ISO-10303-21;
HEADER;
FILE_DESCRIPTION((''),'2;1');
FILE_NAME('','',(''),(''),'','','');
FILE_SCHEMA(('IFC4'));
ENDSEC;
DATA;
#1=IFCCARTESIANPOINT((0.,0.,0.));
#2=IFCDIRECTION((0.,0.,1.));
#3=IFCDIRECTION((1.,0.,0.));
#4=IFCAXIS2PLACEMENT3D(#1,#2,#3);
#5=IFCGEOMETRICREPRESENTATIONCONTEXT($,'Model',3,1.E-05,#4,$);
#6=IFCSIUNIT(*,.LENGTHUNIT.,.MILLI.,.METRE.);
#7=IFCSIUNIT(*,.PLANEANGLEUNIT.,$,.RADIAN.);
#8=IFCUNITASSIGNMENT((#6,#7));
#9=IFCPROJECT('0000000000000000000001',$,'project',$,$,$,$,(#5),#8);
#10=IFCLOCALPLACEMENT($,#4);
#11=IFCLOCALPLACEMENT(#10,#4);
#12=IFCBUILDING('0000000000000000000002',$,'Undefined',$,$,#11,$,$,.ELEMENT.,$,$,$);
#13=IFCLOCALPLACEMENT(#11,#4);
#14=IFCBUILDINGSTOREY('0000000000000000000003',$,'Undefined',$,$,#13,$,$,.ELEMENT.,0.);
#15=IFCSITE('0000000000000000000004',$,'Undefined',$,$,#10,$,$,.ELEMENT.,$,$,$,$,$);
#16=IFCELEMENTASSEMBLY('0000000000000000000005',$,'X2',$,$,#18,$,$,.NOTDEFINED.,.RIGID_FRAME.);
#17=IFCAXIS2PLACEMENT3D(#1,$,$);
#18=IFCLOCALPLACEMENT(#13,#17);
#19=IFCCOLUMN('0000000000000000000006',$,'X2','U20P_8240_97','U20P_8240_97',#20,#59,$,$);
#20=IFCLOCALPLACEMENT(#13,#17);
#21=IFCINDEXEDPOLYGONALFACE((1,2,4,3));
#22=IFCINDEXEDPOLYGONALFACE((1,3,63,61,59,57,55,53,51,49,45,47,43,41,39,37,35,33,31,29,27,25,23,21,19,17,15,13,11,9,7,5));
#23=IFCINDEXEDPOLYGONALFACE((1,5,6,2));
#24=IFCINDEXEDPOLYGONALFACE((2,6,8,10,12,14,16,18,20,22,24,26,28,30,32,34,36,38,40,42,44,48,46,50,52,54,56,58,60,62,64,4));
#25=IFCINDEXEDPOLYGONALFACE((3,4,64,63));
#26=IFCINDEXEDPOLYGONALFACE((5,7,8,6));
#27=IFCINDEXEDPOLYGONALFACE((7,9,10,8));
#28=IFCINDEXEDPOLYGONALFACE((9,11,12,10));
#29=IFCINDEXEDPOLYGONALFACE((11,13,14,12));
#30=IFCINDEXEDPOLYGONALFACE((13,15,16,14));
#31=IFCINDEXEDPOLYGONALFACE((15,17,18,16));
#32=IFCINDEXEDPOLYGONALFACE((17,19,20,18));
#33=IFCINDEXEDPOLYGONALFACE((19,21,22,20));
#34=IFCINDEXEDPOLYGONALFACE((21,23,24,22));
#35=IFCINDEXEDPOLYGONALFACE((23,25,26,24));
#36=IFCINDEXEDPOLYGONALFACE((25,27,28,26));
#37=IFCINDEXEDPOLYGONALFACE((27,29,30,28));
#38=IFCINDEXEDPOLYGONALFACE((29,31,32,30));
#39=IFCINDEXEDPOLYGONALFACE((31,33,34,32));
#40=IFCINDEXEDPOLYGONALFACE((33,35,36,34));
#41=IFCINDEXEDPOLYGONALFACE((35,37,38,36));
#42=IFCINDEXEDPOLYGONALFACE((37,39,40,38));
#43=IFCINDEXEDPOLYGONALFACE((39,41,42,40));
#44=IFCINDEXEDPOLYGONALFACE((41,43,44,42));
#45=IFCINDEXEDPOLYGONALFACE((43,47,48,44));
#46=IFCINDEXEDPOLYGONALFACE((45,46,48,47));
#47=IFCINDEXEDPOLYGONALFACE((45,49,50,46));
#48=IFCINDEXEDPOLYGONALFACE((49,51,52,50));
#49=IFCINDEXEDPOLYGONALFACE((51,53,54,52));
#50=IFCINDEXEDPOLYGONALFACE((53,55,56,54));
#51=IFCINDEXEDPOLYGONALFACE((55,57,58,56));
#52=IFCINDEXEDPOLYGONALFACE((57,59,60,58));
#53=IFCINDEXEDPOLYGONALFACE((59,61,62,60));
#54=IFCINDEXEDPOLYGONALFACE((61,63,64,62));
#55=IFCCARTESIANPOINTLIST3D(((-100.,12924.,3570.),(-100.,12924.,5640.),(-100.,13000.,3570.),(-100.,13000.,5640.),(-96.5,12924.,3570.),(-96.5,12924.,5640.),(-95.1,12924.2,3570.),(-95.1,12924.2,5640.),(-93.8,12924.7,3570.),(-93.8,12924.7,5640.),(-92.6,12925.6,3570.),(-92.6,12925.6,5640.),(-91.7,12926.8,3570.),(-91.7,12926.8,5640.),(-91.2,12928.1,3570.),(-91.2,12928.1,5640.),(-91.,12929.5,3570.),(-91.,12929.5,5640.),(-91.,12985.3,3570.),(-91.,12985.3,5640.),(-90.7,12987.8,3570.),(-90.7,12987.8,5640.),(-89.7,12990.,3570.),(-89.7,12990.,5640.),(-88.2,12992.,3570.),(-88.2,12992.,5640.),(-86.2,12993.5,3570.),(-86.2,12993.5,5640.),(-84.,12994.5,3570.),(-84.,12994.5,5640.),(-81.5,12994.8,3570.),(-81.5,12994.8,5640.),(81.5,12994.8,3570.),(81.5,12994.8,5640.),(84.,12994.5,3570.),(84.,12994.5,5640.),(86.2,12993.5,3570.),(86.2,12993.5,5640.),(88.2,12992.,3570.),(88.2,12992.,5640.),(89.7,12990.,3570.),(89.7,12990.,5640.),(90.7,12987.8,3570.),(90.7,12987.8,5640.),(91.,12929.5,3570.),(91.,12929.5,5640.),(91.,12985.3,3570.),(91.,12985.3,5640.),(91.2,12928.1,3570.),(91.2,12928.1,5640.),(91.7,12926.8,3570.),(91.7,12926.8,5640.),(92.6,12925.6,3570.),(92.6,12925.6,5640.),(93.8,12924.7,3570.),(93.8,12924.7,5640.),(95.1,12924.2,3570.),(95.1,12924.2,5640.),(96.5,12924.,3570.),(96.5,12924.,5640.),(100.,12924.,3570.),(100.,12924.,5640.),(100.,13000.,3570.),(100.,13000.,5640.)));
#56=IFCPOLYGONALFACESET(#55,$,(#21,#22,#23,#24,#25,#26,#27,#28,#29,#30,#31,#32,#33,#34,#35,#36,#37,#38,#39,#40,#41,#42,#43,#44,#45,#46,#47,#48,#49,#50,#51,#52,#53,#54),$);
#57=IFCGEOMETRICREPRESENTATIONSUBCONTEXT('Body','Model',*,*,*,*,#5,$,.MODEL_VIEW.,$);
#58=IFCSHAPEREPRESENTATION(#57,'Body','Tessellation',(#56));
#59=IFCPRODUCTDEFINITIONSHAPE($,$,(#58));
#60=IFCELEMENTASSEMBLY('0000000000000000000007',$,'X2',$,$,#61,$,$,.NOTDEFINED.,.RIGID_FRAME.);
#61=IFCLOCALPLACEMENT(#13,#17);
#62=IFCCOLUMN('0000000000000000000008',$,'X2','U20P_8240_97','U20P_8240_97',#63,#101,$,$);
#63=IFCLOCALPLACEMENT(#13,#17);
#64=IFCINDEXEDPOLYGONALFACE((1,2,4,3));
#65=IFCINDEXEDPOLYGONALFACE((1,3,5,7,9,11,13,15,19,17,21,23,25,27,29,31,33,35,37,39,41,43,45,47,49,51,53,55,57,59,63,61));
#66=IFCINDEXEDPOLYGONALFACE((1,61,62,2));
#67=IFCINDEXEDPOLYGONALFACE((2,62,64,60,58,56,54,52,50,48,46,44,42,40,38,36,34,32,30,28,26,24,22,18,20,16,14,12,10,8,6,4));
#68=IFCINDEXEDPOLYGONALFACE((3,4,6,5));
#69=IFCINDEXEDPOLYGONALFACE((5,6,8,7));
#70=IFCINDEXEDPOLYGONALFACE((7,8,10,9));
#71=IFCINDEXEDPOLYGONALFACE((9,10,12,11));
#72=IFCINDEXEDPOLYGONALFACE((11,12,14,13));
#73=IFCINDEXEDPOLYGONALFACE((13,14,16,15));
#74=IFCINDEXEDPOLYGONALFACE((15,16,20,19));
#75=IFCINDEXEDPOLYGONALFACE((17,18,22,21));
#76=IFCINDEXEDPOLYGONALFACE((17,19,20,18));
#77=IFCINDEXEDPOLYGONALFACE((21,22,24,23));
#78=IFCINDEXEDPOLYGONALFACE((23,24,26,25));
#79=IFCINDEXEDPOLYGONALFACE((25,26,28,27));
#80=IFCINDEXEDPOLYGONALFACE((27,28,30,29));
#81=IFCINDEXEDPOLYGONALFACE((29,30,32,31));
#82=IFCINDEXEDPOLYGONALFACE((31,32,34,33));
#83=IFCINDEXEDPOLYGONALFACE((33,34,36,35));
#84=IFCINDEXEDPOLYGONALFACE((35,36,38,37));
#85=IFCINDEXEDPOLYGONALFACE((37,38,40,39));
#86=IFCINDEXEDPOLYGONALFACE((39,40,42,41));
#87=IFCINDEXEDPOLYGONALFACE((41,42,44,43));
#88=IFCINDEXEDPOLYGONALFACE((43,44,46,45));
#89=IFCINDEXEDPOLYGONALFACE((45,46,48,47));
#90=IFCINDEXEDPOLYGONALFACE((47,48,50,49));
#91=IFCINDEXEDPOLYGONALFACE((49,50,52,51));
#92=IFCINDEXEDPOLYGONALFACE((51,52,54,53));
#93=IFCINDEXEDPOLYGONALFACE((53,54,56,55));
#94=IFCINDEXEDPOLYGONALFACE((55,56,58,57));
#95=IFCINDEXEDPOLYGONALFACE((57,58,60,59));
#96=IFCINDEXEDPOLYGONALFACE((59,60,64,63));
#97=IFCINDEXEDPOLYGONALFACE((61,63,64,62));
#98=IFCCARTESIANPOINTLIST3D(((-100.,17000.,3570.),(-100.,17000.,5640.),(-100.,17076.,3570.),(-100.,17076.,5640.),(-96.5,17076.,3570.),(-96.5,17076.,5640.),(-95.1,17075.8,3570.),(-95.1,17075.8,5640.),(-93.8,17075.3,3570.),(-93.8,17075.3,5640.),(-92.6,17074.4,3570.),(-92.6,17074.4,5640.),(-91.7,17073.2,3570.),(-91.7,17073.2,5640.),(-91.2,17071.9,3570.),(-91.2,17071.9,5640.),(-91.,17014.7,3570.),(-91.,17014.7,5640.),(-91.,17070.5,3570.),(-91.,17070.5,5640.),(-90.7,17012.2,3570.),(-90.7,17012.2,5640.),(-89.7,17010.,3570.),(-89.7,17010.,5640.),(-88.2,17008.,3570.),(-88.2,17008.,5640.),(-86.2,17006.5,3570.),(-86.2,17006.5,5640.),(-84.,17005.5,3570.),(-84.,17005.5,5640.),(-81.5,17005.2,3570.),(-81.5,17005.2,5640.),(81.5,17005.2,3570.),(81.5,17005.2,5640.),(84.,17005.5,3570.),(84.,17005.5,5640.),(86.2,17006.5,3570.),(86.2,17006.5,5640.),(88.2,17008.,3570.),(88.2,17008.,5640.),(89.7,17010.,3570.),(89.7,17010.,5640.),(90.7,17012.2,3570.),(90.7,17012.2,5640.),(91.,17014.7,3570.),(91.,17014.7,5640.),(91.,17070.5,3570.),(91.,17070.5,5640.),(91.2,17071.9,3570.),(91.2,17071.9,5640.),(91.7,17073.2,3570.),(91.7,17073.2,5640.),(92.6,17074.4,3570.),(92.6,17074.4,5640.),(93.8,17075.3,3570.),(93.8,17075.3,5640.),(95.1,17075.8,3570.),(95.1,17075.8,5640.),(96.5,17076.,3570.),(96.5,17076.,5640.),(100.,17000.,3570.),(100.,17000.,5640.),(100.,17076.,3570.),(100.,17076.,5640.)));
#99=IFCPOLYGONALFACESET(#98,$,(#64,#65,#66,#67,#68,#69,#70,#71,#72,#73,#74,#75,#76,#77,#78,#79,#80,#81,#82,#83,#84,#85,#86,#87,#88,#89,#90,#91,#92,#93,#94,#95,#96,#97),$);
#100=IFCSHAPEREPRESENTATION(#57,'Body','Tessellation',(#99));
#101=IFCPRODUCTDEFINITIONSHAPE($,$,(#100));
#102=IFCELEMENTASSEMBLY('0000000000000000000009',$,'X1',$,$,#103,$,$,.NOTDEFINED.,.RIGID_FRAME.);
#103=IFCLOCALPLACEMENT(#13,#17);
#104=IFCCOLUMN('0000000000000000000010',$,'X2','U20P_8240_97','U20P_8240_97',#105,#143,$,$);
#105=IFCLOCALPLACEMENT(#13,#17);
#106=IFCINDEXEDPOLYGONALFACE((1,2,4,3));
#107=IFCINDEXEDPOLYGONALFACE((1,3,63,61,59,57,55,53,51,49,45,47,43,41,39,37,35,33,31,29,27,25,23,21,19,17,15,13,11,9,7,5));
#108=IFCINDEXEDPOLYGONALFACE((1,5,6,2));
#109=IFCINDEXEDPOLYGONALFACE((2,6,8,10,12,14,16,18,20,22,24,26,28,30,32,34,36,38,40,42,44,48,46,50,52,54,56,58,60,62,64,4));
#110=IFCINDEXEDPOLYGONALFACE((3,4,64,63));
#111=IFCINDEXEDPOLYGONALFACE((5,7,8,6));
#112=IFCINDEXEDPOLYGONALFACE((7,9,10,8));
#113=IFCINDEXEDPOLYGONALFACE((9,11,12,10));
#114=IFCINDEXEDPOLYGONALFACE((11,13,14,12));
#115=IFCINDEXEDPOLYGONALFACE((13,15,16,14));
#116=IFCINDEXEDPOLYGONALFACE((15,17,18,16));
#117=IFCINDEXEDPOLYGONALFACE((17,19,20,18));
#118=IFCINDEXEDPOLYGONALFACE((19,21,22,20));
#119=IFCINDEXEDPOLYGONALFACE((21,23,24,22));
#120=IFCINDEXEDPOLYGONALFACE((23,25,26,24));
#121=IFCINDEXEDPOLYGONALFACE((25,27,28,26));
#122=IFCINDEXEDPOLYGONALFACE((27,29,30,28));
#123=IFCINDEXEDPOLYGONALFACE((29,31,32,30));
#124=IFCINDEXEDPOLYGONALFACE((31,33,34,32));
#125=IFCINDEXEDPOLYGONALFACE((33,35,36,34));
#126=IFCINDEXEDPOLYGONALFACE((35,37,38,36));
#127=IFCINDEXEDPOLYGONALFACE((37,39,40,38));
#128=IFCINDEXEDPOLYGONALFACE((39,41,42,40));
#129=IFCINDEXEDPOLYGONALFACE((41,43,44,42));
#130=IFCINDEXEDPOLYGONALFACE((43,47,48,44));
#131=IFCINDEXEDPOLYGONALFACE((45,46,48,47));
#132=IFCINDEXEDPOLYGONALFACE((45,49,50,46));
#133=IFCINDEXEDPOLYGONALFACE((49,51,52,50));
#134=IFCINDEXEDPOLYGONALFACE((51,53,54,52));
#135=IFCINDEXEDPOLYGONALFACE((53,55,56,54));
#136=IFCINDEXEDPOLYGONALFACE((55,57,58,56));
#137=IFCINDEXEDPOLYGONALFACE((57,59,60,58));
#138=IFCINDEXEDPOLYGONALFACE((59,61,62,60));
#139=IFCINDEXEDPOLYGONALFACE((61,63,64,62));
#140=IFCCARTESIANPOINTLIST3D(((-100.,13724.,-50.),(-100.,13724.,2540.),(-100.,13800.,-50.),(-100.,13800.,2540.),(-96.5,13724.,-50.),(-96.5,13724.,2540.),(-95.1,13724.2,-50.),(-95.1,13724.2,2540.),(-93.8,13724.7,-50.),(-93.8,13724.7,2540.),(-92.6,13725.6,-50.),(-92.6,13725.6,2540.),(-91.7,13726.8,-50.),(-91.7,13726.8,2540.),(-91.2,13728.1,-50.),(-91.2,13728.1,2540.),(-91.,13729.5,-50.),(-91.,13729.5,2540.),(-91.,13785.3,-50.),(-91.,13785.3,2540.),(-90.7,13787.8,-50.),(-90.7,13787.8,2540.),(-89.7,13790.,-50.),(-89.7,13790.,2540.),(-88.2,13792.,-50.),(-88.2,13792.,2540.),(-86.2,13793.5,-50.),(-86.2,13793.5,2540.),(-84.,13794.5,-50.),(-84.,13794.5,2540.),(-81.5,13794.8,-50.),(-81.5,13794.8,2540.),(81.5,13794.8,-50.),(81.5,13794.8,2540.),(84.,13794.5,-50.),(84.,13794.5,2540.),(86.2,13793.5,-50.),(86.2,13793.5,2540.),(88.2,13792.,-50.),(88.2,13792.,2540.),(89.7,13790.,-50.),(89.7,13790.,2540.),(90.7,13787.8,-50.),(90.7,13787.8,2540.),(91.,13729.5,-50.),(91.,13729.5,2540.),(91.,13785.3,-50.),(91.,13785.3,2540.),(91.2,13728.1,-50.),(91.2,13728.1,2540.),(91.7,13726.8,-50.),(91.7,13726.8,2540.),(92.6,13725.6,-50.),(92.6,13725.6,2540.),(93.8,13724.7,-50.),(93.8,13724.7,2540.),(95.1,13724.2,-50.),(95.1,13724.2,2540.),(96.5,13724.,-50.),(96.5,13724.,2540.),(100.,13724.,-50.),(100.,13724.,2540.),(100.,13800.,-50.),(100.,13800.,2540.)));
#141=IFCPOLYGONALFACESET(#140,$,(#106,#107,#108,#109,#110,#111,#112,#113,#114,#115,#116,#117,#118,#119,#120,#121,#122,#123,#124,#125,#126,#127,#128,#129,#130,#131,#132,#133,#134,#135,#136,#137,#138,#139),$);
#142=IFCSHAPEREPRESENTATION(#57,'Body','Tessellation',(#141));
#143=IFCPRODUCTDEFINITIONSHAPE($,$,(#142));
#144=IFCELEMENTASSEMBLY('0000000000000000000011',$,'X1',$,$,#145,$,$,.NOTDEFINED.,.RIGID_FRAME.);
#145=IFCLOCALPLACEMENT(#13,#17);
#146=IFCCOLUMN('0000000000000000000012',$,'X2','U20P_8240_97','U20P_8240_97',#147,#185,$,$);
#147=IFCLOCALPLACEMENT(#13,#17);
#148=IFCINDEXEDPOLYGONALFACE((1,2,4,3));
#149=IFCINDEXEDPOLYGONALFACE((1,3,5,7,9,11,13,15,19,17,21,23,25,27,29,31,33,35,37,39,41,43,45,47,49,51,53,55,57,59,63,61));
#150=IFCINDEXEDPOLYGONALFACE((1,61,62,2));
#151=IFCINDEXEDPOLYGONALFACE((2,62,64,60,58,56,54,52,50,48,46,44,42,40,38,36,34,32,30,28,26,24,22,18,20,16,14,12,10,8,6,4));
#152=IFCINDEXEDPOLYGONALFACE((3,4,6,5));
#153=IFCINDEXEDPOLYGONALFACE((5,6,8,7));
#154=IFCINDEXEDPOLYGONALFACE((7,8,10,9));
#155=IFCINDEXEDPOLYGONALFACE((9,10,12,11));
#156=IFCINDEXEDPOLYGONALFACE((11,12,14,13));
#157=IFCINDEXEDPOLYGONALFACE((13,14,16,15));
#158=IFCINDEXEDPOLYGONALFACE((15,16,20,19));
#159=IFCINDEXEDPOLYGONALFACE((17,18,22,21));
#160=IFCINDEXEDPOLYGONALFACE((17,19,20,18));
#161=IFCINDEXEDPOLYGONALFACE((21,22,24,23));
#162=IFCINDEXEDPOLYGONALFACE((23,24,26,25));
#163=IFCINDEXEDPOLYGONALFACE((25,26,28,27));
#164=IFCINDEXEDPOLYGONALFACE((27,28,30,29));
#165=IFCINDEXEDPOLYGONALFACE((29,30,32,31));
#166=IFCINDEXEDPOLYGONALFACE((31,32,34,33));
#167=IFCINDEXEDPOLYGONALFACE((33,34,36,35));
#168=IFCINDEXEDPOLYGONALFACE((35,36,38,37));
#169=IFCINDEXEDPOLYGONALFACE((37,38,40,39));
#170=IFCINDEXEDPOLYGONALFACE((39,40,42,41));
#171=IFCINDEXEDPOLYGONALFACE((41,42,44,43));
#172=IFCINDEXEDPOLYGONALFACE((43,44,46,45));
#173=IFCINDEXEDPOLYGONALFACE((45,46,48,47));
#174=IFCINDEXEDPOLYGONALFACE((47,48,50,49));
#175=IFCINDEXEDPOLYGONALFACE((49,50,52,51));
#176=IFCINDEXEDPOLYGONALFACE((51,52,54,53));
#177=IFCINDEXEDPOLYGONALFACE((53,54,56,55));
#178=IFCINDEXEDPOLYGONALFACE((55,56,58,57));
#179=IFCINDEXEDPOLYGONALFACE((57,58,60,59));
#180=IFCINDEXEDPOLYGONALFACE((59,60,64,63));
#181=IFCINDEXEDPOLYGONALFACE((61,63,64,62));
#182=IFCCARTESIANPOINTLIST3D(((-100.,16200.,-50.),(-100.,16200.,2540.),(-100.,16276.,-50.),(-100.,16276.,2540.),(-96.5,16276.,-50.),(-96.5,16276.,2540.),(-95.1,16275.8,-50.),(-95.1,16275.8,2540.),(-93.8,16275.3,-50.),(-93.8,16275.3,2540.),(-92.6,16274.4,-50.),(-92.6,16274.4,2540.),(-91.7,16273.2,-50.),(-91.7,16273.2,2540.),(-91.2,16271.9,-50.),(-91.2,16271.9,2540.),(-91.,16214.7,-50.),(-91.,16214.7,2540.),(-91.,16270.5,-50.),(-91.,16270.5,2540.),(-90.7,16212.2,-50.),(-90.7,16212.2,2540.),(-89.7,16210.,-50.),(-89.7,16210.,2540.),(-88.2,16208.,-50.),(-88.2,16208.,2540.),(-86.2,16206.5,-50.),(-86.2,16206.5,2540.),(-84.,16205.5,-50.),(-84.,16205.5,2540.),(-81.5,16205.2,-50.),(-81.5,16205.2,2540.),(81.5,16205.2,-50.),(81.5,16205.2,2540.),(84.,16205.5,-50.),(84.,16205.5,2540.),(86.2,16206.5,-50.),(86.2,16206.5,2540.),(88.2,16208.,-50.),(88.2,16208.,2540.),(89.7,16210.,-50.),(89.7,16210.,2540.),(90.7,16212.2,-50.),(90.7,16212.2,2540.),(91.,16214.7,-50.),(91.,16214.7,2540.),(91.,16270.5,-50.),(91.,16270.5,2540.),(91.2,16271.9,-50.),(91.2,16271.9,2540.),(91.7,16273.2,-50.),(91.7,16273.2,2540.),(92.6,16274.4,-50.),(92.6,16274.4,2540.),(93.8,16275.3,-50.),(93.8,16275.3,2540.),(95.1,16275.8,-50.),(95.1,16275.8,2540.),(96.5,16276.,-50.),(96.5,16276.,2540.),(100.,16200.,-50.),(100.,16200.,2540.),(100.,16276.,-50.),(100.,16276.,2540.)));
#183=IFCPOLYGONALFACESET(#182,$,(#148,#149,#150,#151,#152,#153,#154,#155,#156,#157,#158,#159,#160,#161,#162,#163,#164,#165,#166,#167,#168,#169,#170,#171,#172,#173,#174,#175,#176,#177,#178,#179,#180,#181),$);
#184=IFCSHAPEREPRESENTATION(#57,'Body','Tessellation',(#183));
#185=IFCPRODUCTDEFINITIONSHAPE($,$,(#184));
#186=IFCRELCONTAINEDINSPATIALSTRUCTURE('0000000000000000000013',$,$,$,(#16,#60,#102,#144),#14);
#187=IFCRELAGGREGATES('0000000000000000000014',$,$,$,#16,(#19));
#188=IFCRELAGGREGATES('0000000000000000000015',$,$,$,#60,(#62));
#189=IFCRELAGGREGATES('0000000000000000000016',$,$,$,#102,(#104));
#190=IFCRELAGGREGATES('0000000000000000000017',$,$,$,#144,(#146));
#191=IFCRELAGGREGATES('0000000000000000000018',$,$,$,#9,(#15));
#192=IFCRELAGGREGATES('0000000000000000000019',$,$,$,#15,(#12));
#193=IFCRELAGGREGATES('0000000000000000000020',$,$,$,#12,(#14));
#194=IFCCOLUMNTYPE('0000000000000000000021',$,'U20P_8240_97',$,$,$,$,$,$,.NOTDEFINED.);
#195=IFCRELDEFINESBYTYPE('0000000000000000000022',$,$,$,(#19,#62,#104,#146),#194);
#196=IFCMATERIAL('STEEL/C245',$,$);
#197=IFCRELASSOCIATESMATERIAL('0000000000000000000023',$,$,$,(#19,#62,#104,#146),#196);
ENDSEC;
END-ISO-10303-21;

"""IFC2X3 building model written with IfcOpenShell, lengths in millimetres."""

from ifc_helpers import new_model, si_unit, frame, origin_with_axes, origin_2d_with_axis, place, context, subcontext, project, spatial, u_section, extrude, material, type_object, element, aggregate, save


model = new_model("IFC2X3")

# Units and contexts
model_context = context("Model", 3, precision=1e-05, world=origin_with_axes())
body_context = subcontext(model_context, "Body", "Model", "MODEL_VIEW")
ifc_project = project(units=[si_unit("LENGTHUNIT", "METRE", prefix="MILLI"), si_unit("PLANEANGLEUNIT", "RADIAN")], contexts=[model_context])

# Site, building, storey
site_placement = place(None, origin_with_axes())
site = spatial("IfcSite", under=ifc_project, at=site_placement, Name="Undefined", CompositionType="ELEMENT")
building_placement = place(site_placement, origin_with_axes())
building = spatial("IfcBuilding", under=site, at=building_placement, Name="Undefined", CompositionType="ELEMENT")
storey_placement = place(building_placement, origin_with_axes())
storey = spatial("IfcBuildingStorey", under=building, at=storey_placement, Name="Undefined", CompositionType="ELEMENT", Elevation=0.0)

# Element assemblies, columns
assembly_1_placement = place(storey_placement, origin_with_axes())
assembly_1 = element("IfcElementAssembly", 1, at=assembly_1_placement, inside=storey, Name="X2", AssemblyPlace="NOTDEFINED", PredefinedType="RIGID_FRAME")
ifc_material_1 = material(Name="STEEL/C245")
column_type_1 = type_object("IfcColumnType", Name="U20P_8240_97", PredefinedType="NOTDEFINED")
column_1_placement = place(assembly_1_placement, frame((0.0, 12962.0, 3570.0), z_axis=(0.0, 0.0, 1.0), x_axis=(-1.0, 0.0, 0.0)))
column_1 = element("IfcColumn", 2, at=column_1_placement, type_object=column_type_1, material=ifc_material_1, Name="X2", Description="U20P_8240_97", ObjectType="U20P_8240_97", context=body_context, shape_type="SweptSolid", body=[
    extrude(u_section(Depth=200.0, FlangeWidth=76.0, WebThickness=5.2, FlangeThickness=9.0, FilletRadius=9.5, EdgeRadius=5.5, at=origin_2d_with_axis()), frame((0.0, 0.0, 2070.0), z_axis=(0.0, 0.0, -1.0), x_axis=(0.0, 1.0, 0.0)), (0.0, 0.0, 1.0), 2070.0),
])
aggregate(assembly_1, [column_1])
assembly_2_placement = place(storey_placement, origin_with_axes())
assembly_2 = element("IfcElementAssembly", 3, at=assembly_2_placement, inside=storey, Name="X2", AssemblyPlace="NOTDEFINED", PredefinedType="RIGID_FRAME")
column_2_placement = place(assembly_2_placement, frame((0.0, 17038.0, 3570.0), z_axis=(0.0, 0.0, 1.0), x_axis=(1.0, 0.0, 0.0)))
column_2 = element("IfcColumn", 4, at=column_2_placement, type_object=column_type_1, material=ifc_material_1, Name="X2", Description="U20P_8240_97", ObjectType="U20P_8240_97", context=body_context, shape_type="SweptSolid", body=[
    extrude(u_section(Depth=200.0, FlangeWidth=76.0, WebThickness=5.2, FlangeThickness=9.0, FilletRadius=9.5, EdgeRadius=5.5, at=origin_2d_with_axis()), frame((0.0, 0.0, 2070.0), z_axis=(0.0, 0.0, -1.0), x_axis=(0.0, 1.0, 0.0)), (0.0, 0.0, 1.0), 2070.0),
])
aggregate(assembly_2, [column_2])
assembly_3_placement = place(storey_placement, origin_with_axes())
assembly_3 = element("IfcElementAssembly", 5, at=assembly_3_placement, inside=storey, Name="X1", AssemblyPlace="NOTDEFINED", PredefinedType="RIGID_FRAME")
column_3_placement = place(assembly_3_placement, frame((0.0, 13762.0, -50.0), z_axis=(0.0, 0.0, 1.0), x_axis=(-1.0, 0.0, 0.0)))
column_3 = element("IfcColumn", 6, at=column_3_placement, type_object=column_type_1, material=ifc_material_1, Name="X2", Description="U20P_8240_97", ObjectType="U20P_8240_97", context=body_context, shape_type="SweptSolid", body=[
    extrude(u_section(Depth=200.0, FlangeWidth=76.0, WebThickness=5.2, FlangeThickness=9.0, FilletRadius=9.5, EdgeRadius=5.5, at=origin_2d_with_axis()), frame((0.0, 0.0, 2590.0), z_axis=(0.0, 0.0, -1.0), x_axis=(0.0, 1.0, 0.0)), (0.0, 0.0, 1.0), 2590.0),
])
aggregate(assembly_3, [column_3])
assembly_4_placement = place(storey_placement, origin_with_axes())
assembly_4 = element("IfcElementAssembly", 7, at=assembly_4_placement, inside=storey, Name="X1", AssemblyPlace="NOTDEFINED", PredefinedType="RIGID_FRAME")
column_4_placement = place(assembly_4_placement, frame((0.0, 16238.0, -50.0), z_axis=(0.0, 0.0, 1.0), x_axis=(1.0, 0.0, 0.0)))
column_4 = element("IfcColumn", 8, at=column_4_placement, type_object=column_type_1, material=ifc_material_1, Name="X2", Description="U20P_8240_97", ObjectType="U20P_8240_97", context=body_context, shape_type="SweptSolid", body=[
    extrude(u_section(Depth=200.0, FlangeWidth=76.0, WebThickness=5.2, FlangeThickness=9.0, FilletRadius=9.5, EdgeRadius=5.5, at=origin_2d_with_axis()), frame((0.0, 0.0, 2590.0), z_axis=(0.0, 0.0, -1.0), x_axis=(0.0, 1.0, 0.0)), (0.0, 0.0, 1.0), 2590.0),
])
aggregate(assembly_4, [column_4])

save(model, "model.ifc")
